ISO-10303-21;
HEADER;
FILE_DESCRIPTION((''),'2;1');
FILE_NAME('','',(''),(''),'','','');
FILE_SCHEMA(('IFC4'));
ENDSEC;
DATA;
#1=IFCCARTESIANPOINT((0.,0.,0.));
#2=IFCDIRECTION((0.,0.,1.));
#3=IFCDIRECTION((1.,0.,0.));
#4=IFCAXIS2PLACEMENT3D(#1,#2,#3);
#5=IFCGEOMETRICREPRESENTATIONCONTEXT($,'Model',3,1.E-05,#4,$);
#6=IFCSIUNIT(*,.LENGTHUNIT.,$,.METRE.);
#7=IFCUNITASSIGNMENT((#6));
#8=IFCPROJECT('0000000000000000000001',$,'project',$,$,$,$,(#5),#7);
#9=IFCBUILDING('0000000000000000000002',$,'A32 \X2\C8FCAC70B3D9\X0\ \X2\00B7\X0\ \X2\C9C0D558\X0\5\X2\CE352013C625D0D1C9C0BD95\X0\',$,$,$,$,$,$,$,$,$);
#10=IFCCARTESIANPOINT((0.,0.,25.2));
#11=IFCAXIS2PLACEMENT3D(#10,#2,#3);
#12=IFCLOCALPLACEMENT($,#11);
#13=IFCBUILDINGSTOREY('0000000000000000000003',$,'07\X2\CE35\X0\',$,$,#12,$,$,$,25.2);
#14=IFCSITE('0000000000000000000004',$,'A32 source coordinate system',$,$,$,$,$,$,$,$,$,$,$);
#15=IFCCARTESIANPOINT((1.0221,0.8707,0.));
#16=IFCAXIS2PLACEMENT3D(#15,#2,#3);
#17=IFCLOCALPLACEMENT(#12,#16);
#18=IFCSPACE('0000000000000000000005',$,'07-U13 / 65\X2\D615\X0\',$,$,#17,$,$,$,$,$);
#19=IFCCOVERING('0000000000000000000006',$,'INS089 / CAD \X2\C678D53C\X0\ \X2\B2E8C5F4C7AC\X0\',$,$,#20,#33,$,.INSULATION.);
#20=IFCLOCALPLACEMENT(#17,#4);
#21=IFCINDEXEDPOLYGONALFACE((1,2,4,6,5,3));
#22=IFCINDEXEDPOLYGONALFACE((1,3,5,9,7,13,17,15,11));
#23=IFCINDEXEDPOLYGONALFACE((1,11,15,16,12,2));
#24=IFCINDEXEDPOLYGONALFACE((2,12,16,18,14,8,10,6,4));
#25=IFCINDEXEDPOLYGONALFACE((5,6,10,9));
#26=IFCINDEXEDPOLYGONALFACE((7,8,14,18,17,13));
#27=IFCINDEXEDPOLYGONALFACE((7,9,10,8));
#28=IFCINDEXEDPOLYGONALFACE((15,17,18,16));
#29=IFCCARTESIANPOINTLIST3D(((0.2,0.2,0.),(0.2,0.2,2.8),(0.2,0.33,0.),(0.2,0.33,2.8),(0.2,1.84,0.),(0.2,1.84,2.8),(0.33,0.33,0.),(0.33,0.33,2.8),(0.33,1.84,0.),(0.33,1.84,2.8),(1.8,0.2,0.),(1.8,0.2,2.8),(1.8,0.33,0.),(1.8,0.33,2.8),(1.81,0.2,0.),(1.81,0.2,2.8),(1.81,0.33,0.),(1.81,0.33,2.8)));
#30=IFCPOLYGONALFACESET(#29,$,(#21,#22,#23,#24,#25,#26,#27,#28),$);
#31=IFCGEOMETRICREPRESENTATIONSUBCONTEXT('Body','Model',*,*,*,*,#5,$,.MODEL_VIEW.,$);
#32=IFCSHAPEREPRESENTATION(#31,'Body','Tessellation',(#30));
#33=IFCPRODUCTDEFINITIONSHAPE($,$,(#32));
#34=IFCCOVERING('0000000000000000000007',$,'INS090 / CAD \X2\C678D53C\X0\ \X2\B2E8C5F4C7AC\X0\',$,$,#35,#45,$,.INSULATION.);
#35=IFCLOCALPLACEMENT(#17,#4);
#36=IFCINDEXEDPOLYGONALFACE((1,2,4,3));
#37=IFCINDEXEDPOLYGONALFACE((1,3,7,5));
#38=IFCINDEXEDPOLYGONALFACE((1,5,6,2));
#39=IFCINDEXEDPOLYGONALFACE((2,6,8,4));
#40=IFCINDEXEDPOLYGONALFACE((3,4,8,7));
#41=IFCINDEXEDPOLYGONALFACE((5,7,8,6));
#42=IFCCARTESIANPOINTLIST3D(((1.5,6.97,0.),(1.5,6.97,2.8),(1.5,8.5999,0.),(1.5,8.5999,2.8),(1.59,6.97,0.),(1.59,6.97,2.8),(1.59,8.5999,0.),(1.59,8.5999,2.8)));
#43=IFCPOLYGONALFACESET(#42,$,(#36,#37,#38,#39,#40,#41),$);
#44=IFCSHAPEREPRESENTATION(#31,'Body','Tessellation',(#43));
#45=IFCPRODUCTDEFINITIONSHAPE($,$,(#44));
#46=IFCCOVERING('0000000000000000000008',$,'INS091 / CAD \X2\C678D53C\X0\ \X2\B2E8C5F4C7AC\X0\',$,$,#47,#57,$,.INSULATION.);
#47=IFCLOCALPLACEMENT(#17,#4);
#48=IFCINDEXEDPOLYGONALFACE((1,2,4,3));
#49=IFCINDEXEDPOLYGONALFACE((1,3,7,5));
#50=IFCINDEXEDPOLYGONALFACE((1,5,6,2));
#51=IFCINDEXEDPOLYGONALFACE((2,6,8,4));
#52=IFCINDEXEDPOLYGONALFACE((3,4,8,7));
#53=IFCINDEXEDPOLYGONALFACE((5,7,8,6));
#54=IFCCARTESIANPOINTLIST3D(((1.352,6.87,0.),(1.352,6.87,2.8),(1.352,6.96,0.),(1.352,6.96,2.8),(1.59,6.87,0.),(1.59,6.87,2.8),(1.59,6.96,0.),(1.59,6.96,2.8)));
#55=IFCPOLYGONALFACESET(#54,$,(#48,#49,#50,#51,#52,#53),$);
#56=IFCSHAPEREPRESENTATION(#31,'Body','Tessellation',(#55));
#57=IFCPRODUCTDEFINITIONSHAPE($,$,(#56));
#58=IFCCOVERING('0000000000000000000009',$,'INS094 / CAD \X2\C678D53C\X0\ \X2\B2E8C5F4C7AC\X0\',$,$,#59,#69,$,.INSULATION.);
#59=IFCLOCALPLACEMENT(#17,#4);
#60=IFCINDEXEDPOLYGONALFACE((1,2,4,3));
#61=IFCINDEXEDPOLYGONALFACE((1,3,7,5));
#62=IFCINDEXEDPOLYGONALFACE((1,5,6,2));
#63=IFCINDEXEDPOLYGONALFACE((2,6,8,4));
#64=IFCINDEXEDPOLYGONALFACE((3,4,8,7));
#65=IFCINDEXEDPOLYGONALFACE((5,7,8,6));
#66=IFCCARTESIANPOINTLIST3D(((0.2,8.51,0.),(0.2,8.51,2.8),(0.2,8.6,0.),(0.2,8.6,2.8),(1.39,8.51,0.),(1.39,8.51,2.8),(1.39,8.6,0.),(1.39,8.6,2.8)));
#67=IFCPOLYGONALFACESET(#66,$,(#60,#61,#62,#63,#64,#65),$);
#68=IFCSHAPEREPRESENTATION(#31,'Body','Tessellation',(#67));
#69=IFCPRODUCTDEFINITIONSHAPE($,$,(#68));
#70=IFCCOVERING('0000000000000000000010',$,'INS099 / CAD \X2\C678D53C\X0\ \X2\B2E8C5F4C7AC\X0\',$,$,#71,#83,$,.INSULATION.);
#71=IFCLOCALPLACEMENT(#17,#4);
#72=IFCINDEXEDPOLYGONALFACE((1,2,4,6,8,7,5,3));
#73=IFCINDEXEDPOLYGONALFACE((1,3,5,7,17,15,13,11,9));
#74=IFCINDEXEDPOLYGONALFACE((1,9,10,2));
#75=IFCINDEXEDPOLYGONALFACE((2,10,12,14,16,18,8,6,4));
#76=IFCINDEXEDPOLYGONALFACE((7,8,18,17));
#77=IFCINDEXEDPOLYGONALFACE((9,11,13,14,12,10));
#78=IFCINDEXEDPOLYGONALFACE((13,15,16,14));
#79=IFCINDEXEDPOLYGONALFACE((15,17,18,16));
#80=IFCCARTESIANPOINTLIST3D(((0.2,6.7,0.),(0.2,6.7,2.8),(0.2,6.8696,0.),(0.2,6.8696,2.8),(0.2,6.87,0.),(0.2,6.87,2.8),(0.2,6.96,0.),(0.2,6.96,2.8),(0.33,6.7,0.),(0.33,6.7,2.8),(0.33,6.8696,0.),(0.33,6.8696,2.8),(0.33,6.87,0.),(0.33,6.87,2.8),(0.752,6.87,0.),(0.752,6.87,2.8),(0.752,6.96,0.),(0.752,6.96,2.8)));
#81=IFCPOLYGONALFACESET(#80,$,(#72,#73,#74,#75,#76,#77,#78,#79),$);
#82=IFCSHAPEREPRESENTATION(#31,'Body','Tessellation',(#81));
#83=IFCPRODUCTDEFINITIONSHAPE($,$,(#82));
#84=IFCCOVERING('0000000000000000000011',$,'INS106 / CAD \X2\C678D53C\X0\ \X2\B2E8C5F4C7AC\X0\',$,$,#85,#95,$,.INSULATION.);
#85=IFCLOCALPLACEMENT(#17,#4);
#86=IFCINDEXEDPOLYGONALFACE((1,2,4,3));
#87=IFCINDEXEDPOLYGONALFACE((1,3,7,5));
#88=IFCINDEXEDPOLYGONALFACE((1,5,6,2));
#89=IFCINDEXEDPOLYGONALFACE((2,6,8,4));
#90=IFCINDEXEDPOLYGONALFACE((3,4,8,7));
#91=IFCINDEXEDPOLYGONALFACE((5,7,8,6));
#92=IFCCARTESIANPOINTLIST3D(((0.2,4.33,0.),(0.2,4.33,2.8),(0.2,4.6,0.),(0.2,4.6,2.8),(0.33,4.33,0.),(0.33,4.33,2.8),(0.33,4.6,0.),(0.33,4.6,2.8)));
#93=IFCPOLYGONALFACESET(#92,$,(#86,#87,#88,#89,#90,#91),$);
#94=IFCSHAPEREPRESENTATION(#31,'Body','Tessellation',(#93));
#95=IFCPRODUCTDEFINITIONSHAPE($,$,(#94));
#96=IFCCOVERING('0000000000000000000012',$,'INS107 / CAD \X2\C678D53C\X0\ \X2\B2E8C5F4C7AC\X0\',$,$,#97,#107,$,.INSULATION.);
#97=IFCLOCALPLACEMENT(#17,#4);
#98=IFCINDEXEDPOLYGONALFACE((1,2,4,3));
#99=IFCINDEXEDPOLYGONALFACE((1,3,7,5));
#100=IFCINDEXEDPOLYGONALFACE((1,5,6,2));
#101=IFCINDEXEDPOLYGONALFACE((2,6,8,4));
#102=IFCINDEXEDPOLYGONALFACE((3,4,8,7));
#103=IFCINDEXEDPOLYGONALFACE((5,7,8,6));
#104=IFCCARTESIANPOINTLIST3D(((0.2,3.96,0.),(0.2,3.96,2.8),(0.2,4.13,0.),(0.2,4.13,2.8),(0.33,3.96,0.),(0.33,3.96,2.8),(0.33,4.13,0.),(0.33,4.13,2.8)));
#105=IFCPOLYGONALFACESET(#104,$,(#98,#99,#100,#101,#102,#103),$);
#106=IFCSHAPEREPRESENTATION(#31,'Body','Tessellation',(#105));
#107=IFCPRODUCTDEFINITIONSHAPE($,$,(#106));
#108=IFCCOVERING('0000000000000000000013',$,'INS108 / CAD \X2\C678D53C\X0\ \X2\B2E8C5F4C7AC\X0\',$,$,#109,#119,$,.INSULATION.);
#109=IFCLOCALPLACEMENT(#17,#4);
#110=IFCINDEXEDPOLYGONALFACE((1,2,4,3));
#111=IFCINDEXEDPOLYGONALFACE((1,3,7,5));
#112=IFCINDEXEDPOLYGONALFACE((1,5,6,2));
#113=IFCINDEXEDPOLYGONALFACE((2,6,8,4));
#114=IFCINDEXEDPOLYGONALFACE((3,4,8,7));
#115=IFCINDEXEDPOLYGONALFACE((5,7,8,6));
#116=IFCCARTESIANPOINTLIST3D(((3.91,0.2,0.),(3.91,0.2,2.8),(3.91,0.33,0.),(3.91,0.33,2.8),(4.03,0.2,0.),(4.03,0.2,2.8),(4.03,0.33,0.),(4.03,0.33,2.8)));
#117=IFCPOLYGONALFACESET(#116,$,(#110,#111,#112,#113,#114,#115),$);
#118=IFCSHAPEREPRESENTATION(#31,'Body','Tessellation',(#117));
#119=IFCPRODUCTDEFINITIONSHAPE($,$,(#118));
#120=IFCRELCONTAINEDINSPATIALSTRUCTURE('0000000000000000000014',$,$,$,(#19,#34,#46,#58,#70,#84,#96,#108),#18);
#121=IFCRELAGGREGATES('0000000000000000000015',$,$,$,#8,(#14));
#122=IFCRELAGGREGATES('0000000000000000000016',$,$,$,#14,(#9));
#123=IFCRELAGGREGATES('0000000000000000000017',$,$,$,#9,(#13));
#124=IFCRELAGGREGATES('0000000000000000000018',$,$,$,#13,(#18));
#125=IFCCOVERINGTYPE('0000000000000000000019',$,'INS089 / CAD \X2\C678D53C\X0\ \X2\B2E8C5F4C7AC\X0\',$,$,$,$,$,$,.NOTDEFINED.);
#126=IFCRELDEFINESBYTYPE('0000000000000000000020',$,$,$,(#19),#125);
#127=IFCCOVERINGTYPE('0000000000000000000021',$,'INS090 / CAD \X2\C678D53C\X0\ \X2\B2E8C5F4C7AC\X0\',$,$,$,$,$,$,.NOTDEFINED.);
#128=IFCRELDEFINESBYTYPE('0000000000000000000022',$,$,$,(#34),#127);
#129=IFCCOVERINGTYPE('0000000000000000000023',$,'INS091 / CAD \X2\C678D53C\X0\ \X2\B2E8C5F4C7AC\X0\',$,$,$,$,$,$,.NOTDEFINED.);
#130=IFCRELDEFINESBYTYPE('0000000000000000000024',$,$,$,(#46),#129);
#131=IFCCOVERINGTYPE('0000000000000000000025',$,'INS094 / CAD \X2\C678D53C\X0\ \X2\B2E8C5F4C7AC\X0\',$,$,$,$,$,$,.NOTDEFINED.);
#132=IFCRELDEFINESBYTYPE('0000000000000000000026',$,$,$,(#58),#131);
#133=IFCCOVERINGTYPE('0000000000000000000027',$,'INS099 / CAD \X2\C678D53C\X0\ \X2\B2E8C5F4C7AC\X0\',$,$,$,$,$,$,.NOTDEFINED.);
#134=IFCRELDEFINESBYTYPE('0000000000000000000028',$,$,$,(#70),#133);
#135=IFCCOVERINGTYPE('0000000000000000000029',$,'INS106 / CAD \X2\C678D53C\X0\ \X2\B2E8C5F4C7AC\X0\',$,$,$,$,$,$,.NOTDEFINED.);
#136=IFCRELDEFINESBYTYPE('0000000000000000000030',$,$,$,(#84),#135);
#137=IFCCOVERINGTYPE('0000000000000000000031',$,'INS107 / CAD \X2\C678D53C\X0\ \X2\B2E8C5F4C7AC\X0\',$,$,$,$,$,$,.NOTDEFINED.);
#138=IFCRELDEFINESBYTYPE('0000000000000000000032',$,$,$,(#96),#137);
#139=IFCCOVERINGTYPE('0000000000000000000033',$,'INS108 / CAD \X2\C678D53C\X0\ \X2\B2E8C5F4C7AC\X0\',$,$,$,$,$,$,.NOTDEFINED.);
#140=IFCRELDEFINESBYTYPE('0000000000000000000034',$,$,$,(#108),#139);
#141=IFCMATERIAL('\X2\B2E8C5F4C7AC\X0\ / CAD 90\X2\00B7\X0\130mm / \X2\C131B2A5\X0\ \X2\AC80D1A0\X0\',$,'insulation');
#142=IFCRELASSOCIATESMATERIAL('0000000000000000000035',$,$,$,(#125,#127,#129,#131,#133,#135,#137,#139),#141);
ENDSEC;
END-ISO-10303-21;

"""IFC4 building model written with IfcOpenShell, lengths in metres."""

from ifc_helpers import new_model, si_unit, frame, origin, origin_with_axes, place, context, subcontext, project, spatial, polyline, outline, extrude, source, transform, mapped, material, type_object, type_shapes, element, save


model = new_model("IFC4")

# Units and contexts
model_context = context("Model", 3, precision=1e-05, world=origin_with_axes())
body_context = subcontext(model_context, "Body", "Model", "MODEL_VIEW")
ifc_project = project(units=[si_unit("LENGTHUNIT", "METRE")], contexts=[model_context])

# Site, building, storey
site = spatial("IfcSite", under=ifc_project, Name="A32 source coordinate system")
building = spatial("IfcBuilding", under=site, Name="A32 주거동 · 지하5층–옥탑지붕")
storey_placement = place(None, frame((0.0, 0.0, 25.2), z_axis=(0.0, 0.0, 1.0), x_axis=(1.0, 0.0, 0.0)))
storey = spatial("IfcBuildingStorey", under=building, at=storey_placement, Name="07층", Elevation=25.2)

# Shared definitions
space_placement = place(storey_placement, frame((1.0221, 0.8707, 0.0), z_axis=(0.0, 0.0, 1.0), x_axis=(1.0, 0.0, 0.0)))
space = spatial("IfcSpace", under=storey, at=space_placement, Name="07-U13 / 65형")

# Coverings
ifc_material = material(Name="단열재 / CAD 90·130mm / 성능 검토", Category="insulation")
covering_type_1 = type_object("IfcCoveringType", Name="INS089 / CAD 외피 단열재", PredefinedType="NOTDEFINED", material=ifc_material)
shared_shape_1 = source(origin(), body_context, "Body", "SweptSolid", [
    extrude(outline(polyline([(0.2, 0.33), (0.2, 1.84), (0.33, 1.84), (0.33, 0.33), (1.8, 0.33), (1.81, 0.33), (1.81, 0.2), (1.8, 0.2), (0.2, 0.2), (0.2, 0.33)])), origin(), (0.0, 0.0, 1.0), 2.8),
])
type_shapes(covering_type_1, [shared_shape_1])
covering_1_placement = place(space_placement, origin_with_axes())
element("IfcCovering", 1, at=covering_1_placement, inside=space, type_object=covering_type_1, Name="INS089 / CAD 외피 단열재", PredefinedType="INSULATION", context=body_context, shape_type="MappedRepresentation", body=[
    mapped(shared_shape_1, transform((0.0, 0.0, 0.0), scale=1.0)),
])
covering_type_2 = type_object("IfcCoveringType", Name="INS090 / CAD 외피 단열재", PredefinedType="NOTDEFINED", material=ifc_material)
shared_shape_2 = source(origin(), body_context, "Body", "SweptSolid", [
    extrude(outline(polyline([(1.59, 6.97), (1.5, 6.97), (1.5, 8.5999), (1.59, 8.5999), (1.59, 6.97)])), origin(), (0.0, 0.0, 1.0), 2.8),
])
type_shapes(covering_type_2, [shared_shape_2])
covering_2_placement = place(space_placement, origin_with_axes())
element("IfcCovering", 2, at=covering_2_placement, inside=space, type_object=covering_type_2, Name="INS090 / CAD 외피 단열재", PredefinedType="INSULATION", context=body_context, shape_type="MappedRepresentation", body=[
    mapped(shared_shape_2, transform((0.0, 0.0, 0.0), scale=1.0)),
])
covering_type_3 = type_object("IfcCoveringType", Name="INS091 / CAD 외피 단열재", PredefinedType="NOTDEFINED", material=ifc_material)
shared_shape_3 = source(origin(), body_context, "Body", "SweptSolid", [
    extrude(outline(polyline([(1.59, 6.96), (1.59, 6.87), (1.352, 6.87), (1.352, 6.96), (1.59, 6.96)])), origin(), (0.0, 0.0, 1.0), 2.8),
])
type_shapes(covering_type_3, [shared_shape_3])
covering_3_placement = place(space_placement, origin_with_axes())
element("IfcCovering", 3, at=covering_3_placement, inside=space, type_object=covering_type_3, Name="INS091 / CAD 외피 단열재", PredefinedType="INSULATION", context=body_context, shape_type="MappedRepresentation", body=[
    mapped(shared_shape_3, transform((0.0, 0.0, 0.0), scale=1.0)),
])
covering_type_4 = type_object("IfcCoveringType", Name="INS094 / CAD 외피 단열재", PredefinedType="NOTDEFINED", material=ifc_material)
shared_shape_4 = source(origin(), body_context, "Body", "SweptSolid", [
    extrude(outline(polyline([(1.39, 8.51), (0.2, 8.51), (0.2, 8.6), (1.39, 8.6), (1.39, 8.51)])), origin(), (0.0, 0.0, 1.0), 2.8),
])
type_shapes(covering_type_4, [shared_shape_4])
covering_4_placement = place(space_placement, origin_with_axes())
element("IfcCovering", 4, at=covering_4_placement, inside=space, type_object=covering_type_4, Name="INS094 / CAD 외피 단열재", PredefinedType="INSULATION", context=body_context, shape_type="MappedRepresentation", body=[
    mapped(shared_shape_4, transform((0.0, 0.0, 0.0), scale=1.0)),
])
covering_type_5 = type_object("IfcCoveringType", Name="INS099 / CAD 외피 단열재", PredefinedType="NOTDEFINED", material=ifc_material)
shared_shape_5 = source(origin(), body_context, "Body", "SweptSolid", [
    extrude(outline(polyline([(0.2, 6.8696), (0.2, 6.87), (0.2, 6.96), (0.752, 6.96), (0.752, 6.87), (0.33, 6.87), (0.33, 6.8696), (0.33, 6.7), (0.2, 6.7), (0.2, 6.8696)])), origin(), (0.0, 0.0, 1.0), 2.8),
])
type_shapes(covering_type_5, [shared_shape_5])
covering_5_placement = place(space_placement, origin_with_axes())
element("IfcCovering", 5, at=covering_5_placement, inside=space, type_object=covering_type_5, Name="INS099 / CAD 외피 단열재", PredefinedType="INSULATION", context=body_context, shape_type="MappedRepresentation", body=[
    mapped(shared_shape_5, transform((0.0, 0.0, 0.0), scale=1.0)),
])
covering_type_6 = type_object("IfcCoveringType", Name="INS106 / CAD 외피 단열재", PredefinedType="NOTDEFINED", material=ifc_material)
shared_shape_6 = source(origin(), body_context, "Body", "SweptSolid", [
    extrude(outline(polyline([(0.33, 4.6), (0.33, 4.33), (0.2, 4.33), (0.2, 4.6), (0.33, 4.6)])), origin(), (0.0, 0.0, 1.0), 2.8),
])
type_shapes(covering_type_6, [shared_shape_6])
covering_6_placement = place(space_placement, origin_with_axes())
element("IfcCovering", 6, at=covering_6_placement, inside=space, type_object=covering_type_6, Name="INS106 / CAD 외피 단열재", PredefinedType="INSULATION", context=body_context, shape_type="MappedRepresentation", body=[
    mapped(shared_shape_6, transform((0.0, 0.0, 0.0), scale=1.0)),
])
covering_type_7 = type_object("IfcCoveringType", Name="INS107 / CAD 외피 단열재", PredefinedType="NOTDEFINED", material=ifc_material)
shared_shape_7 = source(origin(), body_context, "Body", "SweptSolid", [
    extrude(outline(polyline([(0.33, 3.96), (0.2, 3.96), (0.2, 4.13), (0.33, 4.13), (0.33, 3.96)])), origin(), (0.0, 0.0, 1.0), 2.8),
])
type_shapes(covering_type_7, [shared_shape_7])
covering_7_placement = place(space_placement, origin_with_axes())
element("IfcCovering", 7, at=covering_7_placement, inside=space, type_object=covering_type_7, Name="INS107 / CAD 외피 단열재", PredefinedType="INSULATION", context=body_context, shape_type="MappedRepresentation", body=[
    mapped(shared_shape_7, transform((0.0, 0.0, 0.0), scale=1.0)),
])
covering_type_8 = type_object("IfcCoveringType", Name="INS108 / CAD 외피 단열재", PredefinedType="NOTDEFINED", material=ifc_material)
shared_shape_8 = source(origin(), body_context, "Body", "SweptSolid", [
    extrude(outline(polyline([(4.03, 0.2), (3.91, 0.2), (3.91, 0.33), (4.03, 0.33), (4.03, 0.2)])), origin(), (0.0, 0.0, 1.0), 2.8),
])
type_shapes(covering_type_8, [shared_shape_8])
covering_8_placement = place(space_placement, origin_with_axes())
element("IfcCovering", 8, at=covering_8_placement, inside=space, type_object=covering_type_8, Name="INS108 / CAD 외피 단열재", PredefinedType="INSULATION", context=body_context, shape_type="MappedRepresentation", body=[
    mapped(shared_shape_8, transform((0.0, 0.0, 0.0), scale=1.0)),
])

save(model, "model.ifc")
